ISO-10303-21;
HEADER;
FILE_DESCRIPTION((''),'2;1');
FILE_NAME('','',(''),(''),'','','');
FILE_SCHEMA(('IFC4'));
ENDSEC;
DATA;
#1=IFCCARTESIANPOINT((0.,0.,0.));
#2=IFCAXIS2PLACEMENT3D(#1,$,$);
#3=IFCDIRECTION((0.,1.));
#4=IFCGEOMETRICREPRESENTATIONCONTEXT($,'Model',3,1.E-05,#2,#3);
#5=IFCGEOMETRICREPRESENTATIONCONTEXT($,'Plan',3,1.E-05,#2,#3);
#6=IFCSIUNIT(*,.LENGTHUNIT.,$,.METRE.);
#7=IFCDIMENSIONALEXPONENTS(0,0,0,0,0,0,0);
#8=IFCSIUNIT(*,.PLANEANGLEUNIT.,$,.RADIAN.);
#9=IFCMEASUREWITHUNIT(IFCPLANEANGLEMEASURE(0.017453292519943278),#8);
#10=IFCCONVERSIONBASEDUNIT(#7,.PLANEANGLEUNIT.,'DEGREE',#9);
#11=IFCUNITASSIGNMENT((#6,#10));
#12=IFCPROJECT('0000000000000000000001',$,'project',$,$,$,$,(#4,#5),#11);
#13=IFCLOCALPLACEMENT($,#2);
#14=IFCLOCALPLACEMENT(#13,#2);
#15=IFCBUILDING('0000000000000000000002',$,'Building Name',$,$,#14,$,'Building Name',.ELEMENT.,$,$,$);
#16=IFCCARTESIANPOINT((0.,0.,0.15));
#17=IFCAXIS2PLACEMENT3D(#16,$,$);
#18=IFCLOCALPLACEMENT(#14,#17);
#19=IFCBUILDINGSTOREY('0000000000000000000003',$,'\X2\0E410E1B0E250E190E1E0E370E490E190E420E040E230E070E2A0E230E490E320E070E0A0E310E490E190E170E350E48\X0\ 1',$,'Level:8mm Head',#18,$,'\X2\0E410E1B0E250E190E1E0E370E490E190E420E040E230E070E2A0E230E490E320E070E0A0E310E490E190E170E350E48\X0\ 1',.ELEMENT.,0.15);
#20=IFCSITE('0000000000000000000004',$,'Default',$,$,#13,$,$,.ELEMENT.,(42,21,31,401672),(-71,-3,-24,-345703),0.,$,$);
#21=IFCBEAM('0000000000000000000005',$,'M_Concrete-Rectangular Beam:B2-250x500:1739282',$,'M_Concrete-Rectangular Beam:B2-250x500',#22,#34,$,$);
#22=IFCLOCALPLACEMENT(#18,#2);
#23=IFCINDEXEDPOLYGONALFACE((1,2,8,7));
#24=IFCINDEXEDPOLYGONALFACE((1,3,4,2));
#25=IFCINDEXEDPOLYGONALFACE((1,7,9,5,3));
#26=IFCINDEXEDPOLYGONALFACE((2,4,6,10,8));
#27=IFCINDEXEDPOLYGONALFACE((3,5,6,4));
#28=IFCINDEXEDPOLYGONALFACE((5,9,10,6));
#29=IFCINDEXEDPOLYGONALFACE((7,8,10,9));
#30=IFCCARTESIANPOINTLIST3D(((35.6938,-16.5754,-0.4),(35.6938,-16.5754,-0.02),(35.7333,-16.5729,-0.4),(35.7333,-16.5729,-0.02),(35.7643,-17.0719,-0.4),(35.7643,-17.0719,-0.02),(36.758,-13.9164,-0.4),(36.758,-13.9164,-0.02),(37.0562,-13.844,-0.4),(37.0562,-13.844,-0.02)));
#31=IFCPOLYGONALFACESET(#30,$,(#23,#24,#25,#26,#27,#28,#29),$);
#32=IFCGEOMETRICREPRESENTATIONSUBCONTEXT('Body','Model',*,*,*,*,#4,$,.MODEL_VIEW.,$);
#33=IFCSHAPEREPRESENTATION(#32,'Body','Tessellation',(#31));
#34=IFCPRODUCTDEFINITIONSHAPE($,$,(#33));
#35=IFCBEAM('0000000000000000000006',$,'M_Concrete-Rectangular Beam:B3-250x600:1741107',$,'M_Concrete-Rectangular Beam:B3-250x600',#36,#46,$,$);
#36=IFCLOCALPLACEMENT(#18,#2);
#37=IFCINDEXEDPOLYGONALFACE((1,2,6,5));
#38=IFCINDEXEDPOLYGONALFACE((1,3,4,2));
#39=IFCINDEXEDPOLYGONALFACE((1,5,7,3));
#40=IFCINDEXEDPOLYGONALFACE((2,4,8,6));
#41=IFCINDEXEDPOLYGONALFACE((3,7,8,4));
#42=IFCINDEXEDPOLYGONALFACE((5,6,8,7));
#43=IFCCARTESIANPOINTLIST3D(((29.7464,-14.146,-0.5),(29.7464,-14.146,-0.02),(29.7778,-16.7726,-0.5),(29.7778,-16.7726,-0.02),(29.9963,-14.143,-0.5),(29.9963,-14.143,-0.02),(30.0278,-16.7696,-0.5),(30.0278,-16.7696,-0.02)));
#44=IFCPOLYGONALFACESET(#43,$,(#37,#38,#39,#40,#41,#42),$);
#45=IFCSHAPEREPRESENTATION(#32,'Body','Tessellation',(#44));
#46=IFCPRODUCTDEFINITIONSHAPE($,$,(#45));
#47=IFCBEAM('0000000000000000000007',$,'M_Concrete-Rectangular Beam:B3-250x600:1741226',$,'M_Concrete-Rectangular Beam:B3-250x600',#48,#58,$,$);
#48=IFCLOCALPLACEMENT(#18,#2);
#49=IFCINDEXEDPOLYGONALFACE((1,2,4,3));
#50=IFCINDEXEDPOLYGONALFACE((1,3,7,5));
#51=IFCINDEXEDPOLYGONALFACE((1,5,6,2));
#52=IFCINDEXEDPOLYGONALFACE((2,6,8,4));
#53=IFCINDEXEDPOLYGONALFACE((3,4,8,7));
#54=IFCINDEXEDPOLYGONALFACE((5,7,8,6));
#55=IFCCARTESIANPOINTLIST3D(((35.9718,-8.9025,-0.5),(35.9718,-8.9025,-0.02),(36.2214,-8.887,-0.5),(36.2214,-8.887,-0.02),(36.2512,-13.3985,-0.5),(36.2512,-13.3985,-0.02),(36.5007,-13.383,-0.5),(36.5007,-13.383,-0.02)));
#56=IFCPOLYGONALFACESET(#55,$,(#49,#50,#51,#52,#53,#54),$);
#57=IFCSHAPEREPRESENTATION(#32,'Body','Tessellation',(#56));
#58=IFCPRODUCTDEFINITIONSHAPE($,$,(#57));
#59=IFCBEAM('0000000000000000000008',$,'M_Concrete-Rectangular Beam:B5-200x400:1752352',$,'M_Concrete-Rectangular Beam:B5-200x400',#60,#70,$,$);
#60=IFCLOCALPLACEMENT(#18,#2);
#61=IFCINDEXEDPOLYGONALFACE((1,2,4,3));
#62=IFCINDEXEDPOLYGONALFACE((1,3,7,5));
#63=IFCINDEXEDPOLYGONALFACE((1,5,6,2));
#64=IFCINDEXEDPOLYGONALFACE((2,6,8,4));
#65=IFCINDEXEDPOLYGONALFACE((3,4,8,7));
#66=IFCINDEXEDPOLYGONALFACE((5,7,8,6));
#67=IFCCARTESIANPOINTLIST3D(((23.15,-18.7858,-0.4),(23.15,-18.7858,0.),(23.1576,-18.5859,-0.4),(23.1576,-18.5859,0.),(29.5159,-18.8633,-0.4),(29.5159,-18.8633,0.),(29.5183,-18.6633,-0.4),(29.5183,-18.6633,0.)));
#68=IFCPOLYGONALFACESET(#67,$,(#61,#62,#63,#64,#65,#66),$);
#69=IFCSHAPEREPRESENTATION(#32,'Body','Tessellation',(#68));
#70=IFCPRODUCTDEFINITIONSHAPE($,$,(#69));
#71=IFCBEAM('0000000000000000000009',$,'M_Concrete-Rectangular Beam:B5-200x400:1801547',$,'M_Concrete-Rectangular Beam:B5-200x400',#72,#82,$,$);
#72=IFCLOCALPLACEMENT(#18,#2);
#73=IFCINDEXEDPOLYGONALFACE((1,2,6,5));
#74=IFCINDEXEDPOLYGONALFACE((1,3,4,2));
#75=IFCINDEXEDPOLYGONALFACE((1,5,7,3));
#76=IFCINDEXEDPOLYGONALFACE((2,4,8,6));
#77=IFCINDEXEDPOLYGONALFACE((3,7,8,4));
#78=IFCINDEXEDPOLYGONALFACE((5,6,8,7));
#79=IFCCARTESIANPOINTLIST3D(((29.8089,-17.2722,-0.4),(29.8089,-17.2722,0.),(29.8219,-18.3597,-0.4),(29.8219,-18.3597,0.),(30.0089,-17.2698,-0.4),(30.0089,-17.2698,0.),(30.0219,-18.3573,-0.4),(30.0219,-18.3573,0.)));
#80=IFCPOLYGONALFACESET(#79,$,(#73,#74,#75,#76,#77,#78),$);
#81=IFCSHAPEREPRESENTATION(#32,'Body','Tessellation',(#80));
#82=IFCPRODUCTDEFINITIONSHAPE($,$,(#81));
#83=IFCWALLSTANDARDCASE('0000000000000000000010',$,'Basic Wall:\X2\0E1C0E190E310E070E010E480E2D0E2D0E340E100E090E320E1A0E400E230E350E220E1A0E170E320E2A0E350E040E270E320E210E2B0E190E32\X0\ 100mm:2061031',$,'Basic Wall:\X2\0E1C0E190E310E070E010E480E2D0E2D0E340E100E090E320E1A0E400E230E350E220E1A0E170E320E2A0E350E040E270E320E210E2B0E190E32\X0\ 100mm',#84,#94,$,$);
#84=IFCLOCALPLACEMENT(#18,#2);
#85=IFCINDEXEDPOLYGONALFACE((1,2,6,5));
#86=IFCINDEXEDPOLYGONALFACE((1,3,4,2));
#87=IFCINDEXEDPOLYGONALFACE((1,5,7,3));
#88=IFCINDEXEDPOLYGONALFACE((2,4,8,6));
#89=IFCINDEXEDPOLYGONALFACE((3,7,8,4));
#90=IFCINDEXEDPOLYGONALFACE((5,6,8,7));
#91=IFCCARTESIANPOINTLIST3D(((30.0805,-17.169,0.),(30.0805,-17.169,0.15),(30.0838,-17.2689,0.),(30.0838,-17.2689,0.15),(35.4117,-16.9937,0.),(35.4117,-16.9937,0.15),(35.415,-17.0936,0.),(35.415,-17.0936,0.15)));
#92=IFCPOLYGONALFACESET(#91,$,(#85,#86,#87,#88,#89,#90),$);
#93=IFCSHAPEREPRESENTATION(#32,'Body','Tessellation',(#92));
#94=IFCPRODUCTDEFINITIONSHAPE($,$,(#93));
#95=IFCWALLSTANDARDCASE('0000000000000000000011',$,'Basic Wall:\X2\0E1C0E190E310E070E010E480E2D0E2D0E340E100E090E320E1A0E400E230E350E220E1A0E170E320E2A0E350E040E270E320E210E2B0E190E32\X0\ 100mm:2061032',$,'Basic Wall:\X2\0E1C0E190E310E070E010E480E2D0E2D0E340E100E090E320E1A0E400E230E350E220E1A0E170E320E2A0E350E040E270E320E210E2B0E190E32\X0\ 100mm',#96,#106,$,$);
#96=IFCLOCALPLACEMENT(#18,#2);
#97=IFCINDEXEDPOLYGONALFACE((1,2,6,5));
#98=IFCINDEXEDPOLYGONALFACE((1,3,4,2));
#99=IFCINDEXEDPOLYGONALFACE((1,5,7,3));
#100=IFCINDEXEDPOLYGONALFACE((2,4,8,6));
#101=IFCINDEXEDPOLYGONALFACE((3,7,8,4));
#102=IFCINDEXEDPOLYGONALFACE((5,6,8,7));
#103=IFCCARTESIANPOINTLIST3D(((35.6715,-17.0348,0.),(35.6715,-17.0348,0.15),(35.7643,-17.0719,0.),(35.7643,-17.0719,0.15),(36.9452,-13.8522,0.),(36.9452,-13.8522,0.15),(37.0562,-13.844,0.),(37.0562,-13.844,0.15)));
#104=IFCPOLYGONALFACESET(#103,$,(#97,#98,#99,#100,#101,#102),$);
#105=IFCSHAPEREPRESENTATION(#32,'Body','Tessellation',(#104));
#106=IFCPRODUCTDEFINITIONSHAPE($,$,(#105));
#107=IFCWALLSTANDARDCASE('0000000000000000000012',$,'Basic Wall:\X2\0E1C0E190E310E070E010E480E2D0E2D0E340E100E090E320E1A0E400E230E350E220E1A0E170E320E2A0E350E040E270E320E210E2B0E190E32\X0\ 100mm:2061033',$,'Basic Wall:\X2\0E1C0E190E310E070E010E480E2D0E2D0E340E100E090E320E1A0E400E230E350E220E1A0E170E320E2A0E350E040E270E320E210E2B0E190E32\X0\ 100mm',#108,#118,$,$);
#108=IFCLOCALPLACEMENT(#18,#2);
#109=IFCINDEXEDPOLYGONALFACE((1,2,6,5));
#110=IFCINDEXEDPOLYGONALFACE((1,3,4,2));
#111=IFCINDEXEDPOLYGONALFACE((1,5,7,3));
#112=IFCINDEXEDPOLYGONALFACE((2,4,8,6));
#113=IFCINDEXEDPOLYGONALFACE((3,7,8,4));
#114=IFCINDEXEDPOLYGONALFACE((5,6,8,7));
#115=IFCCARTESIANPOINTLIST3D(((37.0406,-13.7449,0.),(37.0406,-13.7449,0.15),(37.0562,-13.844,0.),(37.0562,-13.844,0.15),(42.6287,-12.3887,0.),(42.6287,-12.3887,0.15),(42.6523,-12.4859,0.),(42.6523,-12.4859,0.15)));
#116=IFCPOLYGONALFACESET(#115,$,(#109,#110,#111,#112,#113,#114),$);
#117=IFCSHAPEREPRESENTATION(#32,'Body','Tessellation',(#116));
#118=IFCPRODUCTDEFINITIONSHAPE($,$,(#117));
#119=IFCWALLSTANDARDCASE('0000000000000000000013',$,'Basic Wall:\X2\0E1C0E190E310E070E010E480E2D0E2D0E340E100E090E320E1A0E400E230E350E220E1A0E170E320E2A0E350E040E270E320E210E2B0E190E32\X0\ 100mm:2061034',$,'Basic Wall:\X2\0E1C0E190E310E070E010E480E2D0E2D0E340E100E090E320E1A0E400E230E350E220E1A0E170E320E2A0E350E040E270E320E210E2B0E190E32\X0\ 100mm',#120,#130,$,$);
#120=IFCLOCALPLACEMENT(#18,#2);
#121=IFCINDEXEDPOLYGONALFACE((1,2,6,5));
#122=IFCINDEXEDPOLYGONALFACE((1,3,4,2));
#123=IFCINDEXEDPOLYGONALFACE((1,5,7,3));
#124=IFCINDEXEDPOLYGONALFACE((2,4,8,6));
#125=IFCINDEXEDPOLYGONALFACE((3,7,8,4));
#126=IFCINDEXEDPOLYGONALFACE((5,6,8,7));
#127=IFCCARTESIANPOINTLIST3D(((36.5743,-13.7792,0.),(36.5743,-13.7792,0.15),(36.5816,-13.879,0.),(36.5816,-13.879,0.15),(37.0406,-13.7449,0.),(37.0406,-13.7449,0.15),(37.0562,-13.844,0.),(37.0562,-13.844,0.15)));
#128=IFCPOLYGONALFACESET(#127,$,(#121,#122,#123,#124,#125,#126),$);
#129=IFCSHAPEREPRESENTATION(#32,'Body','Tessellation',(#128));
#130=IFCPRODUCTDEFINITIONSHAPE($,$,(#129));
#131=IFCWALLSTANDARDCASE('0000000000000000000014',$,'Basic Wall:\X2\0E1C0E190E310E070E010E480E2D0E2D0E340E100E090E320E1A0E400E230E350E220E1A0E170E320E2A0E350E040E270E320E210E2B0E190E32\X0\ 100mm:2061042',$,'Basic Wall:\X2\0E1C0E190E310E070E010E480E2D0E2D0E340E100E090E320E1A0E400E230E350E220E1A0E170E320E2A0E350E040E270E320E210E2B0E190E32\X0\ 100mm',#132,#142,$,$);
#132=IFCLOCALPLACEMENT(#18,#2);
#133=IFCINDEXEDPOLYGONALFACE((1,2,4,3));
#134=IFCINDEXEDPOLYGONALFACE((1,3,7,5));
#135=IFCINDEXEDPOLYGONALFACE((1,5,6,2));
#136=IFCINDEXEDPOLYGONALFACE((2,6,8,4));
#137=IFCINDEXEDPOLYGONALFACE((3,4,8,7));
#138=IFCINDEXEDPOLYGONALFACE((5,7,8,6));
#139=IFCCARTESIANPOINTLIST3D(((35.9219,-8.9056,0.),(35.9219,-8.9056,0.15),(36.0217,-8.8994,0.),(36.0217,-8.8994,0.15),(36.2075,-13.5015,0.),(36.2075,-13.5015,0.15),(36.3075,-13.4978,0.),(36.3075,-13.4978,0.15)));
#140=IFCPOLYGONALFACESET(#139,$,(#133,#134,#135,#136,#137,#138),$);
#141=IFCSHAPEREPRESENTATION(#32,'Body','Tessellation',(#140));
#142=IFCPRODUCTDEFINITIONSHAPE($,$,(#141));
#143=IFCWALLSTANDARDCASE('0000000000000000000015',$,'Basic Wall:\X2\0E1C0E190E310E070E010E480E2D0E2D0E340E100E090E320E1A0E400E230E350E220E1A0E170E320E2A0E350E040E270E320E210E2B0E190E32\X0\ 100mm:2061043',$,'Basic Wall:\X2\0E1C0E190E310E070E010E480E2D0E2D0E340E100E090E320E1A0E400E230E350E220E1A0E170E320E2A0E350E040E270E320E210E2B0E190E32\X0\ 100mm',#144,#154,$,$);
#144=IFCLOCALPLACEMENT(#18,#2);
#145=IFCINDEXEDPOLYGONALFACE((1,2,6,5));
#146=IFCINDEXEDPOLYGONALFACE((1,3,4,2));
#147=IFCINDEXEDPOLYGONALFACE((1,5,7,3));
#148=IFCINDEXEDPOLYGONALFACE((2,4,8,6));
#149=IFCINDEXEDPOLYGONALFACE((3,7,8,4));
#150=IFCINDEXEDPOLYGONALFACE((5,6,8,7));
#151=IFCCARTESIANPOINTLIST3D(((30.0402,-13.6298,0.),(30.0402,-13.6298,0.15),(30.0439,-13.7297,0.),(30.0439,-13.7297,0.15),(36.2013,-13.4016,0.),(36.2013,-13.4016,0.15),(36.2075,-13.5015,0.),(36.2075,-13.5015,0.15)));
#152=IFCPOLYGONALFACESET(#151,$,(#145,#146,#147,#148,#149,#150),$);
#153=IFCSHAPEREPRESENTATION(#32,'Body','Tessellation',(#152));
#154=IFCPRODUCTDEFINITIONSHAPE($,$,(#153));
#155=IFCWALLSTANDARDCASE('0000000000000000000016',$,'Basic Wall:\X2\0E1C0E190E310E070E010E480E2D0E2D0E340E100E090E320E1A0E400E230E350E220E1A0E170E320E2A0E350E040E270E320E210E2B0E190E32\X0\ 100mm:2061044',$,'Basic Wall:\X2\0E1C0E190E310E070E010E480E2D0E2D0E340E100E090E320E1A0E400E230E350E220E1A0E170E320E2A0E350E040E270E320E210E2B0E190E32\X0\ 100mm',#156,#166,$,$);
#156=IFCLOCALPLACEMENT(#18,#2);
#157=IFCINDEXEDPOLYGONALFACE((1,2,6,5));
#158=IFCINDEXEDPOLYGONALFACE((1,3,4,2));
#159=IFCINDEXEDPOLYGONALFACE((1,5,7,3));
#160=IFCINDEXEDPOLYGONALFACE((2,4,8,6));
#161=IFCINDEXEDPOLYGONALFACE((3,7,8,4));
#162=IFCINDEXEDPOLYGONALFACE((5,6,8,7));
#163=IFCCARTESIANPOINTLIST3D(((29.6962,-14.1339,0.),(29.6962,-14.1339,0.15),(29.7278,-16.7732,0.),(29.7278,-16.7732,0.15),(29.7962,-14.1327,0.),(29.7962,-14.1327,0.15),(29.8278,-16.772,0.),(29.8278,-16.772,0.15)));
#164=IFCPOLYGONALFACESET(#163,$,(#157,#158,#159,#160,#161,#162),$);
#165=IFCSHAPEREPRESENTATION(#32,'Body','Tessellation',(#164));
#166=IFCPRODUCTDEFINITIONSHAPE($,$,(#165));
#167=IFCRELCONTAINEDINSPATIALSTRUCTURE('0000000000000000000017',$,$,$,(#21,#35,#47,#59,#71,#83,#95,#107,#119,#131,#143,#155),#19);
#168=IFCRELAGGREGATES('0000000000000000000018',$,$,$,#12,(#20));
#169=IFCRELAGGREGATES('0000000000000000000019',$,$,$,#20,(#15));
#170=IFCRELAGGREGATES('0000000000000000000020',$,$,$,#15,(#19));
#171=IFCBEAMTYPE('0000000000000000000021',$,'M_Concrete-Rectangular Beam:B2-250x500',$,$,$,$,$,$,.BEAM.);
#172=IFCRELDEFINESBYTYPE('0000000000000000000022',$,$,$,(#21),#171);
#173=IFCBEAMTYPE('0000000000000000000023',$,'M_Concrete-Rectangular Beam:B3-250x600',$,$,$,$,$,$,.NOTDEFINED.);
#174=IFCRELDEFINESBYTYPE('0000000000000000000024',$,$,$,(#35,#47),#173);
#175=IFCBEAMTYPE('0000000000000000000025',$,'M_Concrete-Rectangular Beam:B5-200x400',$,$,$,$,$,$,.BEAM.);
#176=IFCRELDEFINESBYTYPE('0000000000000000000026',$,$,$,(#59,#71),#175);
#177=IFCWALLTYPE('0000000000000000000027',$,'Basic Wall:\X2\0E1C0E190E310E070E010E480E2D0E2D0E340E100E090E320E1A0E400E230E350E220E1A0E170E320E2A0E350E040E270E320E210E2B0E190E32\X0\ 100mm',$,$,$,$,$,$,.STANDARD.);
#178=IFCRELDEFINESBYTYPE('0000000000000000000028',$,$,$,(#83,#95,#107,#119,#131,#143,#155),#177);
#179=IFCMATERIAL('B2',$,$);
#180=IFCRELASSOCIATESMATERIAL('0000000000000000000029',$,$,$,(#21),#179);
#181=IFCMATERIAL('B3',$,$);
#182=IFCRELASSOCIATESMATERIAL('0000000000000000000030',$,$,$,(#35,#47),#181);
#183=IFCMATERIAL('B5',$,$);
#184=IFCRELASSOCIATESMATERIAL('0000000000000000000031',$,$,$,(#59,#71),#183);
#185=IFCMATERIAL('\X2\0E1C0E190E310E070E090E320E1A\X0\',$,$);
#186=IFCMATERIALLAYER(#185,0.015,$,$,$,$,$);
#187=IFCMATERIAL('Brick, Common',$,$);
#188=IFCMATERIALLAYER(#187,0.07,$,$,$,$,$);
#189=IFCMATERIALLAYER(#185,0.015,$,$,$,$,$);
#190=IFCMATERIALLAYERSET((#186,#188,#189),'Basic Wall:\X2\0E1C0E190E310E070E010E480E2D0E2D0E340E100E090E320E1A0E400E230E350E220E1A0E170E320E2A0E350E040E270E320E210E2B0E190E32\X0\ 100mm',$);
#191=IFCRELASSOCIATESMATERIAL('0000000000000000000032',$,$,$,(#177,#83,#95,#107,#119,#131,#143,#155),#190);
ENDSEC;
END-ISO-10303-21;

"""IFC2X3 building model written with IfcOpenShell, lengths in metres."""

from ifc_helpers import new_model, entity, si_unit, converted_unit, direction, frame, frame_2d, origin, origin_2d_with_axis, place, context, subcontext, project, spatial, polyline, rectangle, outline, extrude, clip, halfspace, bounded_halfspace, material, layer, layer_set, layer_usage, type_object, element, save


model = new_model("IFC2X3")

# Units and contexts
model_context = context("Model", 3, precision=1e-05, world=origin(), true_north=direction((0.0, 1.0)))
plan_context = context("Plan", 3, precision=1e-05, world=origin(), true_north=direction((0.0, 1.0)))
body_context = subcontext(model_context, "Body", "Model", "MODEL_VIEW")
ifc_project = project(units=[si_unit("LENGTHUNIT", "METRE"), converted_unit("PLANEANGLEUNIT", "DEGREE", entity("IfcPlaneAngleMeasure", 0.017453292519943278), si_unit("PLANEANGLEUNIT", "RADIAN"), dimensions=[0, 0, 0, 0, 0, 0, 0])], contexts=[model_context, plan_context])

# Site, building, storey
site_placement = place(None, origin())
site = spatial("IfcSite", under=ifc_project, at=site_placement, Name="Default", CompositionType="ELEMENT", RefLatitude=(42, 21, 31, 401672), RefLongitude=(-71, -3, -24, -345703), RefElevation=0.0)
building_placement = place(site_placement, origin())
building = spatial("IfcBuilding", under=site, at=building_placement, Name="Building Name", LongName="Building Name", CompositionType="ELEMENT")
storey_placement = place(building_placement, frame((0.0, 0.0, 0.15)))
storey = spatial("IfcBuildingStorey", under=building, at=storey_placement, Name="แปลนพื้นโครงสร้างชั้นที่ 1", ObjectType="Level:8mm Head", LongName="แปลนพื้นโครงสร้างชั้นที่ 1", CompositionType="ELEMENT", Elevation=0.15)

# Beams
ifc_material_1 = material(Name="B2")
beam_type_1 = type_object("IfcBeamType", Name="M_Concrete-Rectangular Beam:B2-250x500", PredefinedType="BEAM")
beam_1_placement = place(storey_placement, frame((37.0562, -13.844, 0.0), z_axis=(0.0, 0.0, 1.0), x_axis=(-0.371573, -0.928404, 0.0)))
element("IfcBeam", 1, at=beam_1_placement, inside=storey, type_object=beam_type_1, material=ifc_material_1, Name="M_Concrete-Rectangular Beam:B2-250x500:1739282", ObjectType="M_Concrete-Rectangular Beam:B2-250x500", context=body_context, shape_type="Clipping", body=[
    clip(clip(clip(extrude(rectangle(XDim=0.38, YDim=0.25, at=frame_2d((0.0, 0.0), x_axis=(1.0, 0.0))), frame((0.0, -0.125, -0.21), z_axis=(1.0, 0.0, 0.0), x_axis=(0.0, 0.0, -1.0)), (0.0, 0.0, 1.0), 3.4768), halfspace(frame((0.2918, -0.4098, -0.4), z_axis=(-0.814578, -0.580053, 0.0), x_axis=(-0.580053, 0.814578, 0.0)), False)), bounded_halfspace(frame((3.4768, 0.0, 5.1), z_axis=(0.428432, -0.903574, 0.0), x_axis=(0.0, 0.0, -1.0)), False, frame((0.0, -0.125, -0.21), z_axis=(1.0, 0.0, 0.0), x_axis=(0.0, 0.0, -1.0)), polyline([(0.19, -0.0892), (0.19, 0.125), (-0.19, 0.125), (-0.19, -0.0892), (0.19, -0.0892)]))), bounded_halfspace(frame((3.0251, -0.2142, 5.1), z_axis=(0.903574, 0.428432, 0.0), x_axis=(0.0, 0.0, -1.0)), False, frame((0.0, -0.125, -0.21), z_axis=(1.0, 0.0, 0.0), x_axis=(0.0, 0.0, -1.0)), polyline([(0.19, -0.125), (0.19, -0.0892), (-0.19, -0.0892), (-0.19, -0.125), (0.19, -0.125)]))),
])
ifc_material_2 = material(Name="B3")
beam_type_2 = type_object("IfcBeamType", Name="M_Concrete-Rectangular Beam:B3-250x600", PredefinedType="NOTDEFINED")
beam_2_placement = place(storey_placement, frame((29.9028, -16.7711, 0.0), z_axis=(0.0, 0.0, 1.0), x_axis=(-0.011969, 0.999928, 0.0)))
element("IfcBeam", 2, at=beam_2_placement, inside=storey, type_object=beam_type_2, material=ifc_material_2, Name="M_Concrete-Rectangular Beam:B3-250x600:1741107", ObjectType="M_Concrete-Rectangular Beam:B3-250x600", context=body_context, shape_type="SweptSolid", body=[
    extrude(rectangle(XDim=0.48, YDim=0.25, at=frame_2d((0.0, 0.0), x_axis=(1.0, 0.0))), frame((0.0, 0.0, -0.26), z_axis=(1.0, 0.0, 0.0), x_axis=(0.0, 0.0, -1.0)), (0.0, 0.0, 1.0), 2.6267),
])
beam_3_placement = place(storey_placement, frame((36.3915, -13.6403, 0.0), z_axis=(0.0, 0.0, 1.0), x_axis=(-0.062014, 0.998075, 0.0)))
element("IfcBeam", 3, at=beam_3_placement, inside=storey, type_object=beam_type_2, material=ifc_material_2, Name="M_Concrete-Rectangular Beam:B3-250x600:1741226", ObjectType="M_Concrete-Rectangular Beam:B3-250x600", context=body_context, shape_type="SweptSolid", body=[
    extrude(rectangle(XDim=0.48, YDim=0.25, at=frame_2d((0.0, 0.0), x_axis=(1.0, 0.0))), frame((0.25, 0.0, -0.26), z_axis=(1.0, 0.0, 0.0), x_axis=(0.0, 0.0, -1.0)), (0.0, 0.0, 1.0), 4.5047),
])
ifc_material_3 = material(Name="B5")
beam_type_3 = type_object("IfcBeamType", Name="M_Concrete-Rectangular Beam:B5-200x400", PredefinedType="BEAM")
beam_4_placement = place(storey_placement, frame((29.5159, -18.8633, 0.0), z_axis=(0.0, 0.0, 1.0), x_axis=(-0.999926, 0.01216, 0.0)))
element("IfcBeam", 4, at=beam_4_placement, inside=storey, type_object=beam_type_3, material=ifc_material_3, Name="M_Concrete-Rectangular Beam:B5-200x400:1752352", ObjectType="M_Concrete-Rectangular Beam:B5-200x400", context=body_context, shape_type="Clipping", body=[
    clip(extrude(rectangle(XDim=0.4, YDim=0.2, at=origin_2d_with_axis()), frame((0.0, -0.1, -0.2), z_axis=(1.0, 0.0, 0.0), x_axis=(0.0, 0.0, -1.0)), (0.0, 0.0, 1.0), 6.3664), halfspace(frame((6.3612, -0.2, 0.0), z_axis=(0.999667, -0.025823, 0.0), x_axis=(-0.025823, -0.999667, 0.0)), False)),
])
beam_5_placement = place(storey_placement, frame((30.0089, -17.2698, 0.0), z_axis=(0.0, 0.0, 1.0), x_axis=(0.011969, -0.999928, 0.0)))
element("IfcBeam", 5, at=beam_5_placement, inside=storey, type_object=beam_type_3, material=ifc_material_3, Name="M_Concrete-Rectangular Beam:B5-200x400:1801547", ObjectType="M_Concrete-Rectangular Beam:B5-200x400", context=body_context, shape_type="SweptSolid", body=[
    extrude(rectangle(XDim=0.4, YDim=0.2, at=frame_2d((0.0, 0.0), x_axis=(1.0, 0.0))), frame((0.0, -0.1, -0.2), z_axis=(1.0, 0.0, 0.0), x_axis=(0.0, 0.0, -1.0)), (0.0, 0.0, 1.0), 1.0876),
])

# Walls
ifc_material_4 = material(Name="ผนังฉาบ")
ifc_layer_1 = layer(ifc_material_4, 0.015)
ifc_material_5 = material(Name="Brick, Common")
ifc_layer_2 = layer(ifc_material_5, 0.07)
ifc_layer_3 = layer(ifc_material_4, 0.015)
ifc_layer_set_1 = layer_set([ifc_layer_1, ifc_layer_2, ifc_layer_3], Name="Basic Wall:ผนังก่ออิฐฉาบเรียบทาสีความหนา 100mm")
ifc_layer_usage_1 = layer_usage(ifc_layer_set_1, "AXIS2", "POSITIVE", -0.05)
wall_type_1 = type_object("IfcWallType", Name="Basic Wall:ผนังก่ออิฐฉาบเรียบทาสีความหนา 100mm", PredefinedType="STANDARD", material=ifc_layer_set_1)
wall_1_placement = place(storey_placement, frame((30.0821, -17.219, 0.0), z_axis=(0.0, 0.0, 1.0), x_axis=(0.99946, 0.032862, 0.0)))
element("IfcWallStandardCase", 6, at=wall_1_placement, inside=storey, type_object=wall_type_1, material=ifc_layer_usage_1, Name="Basic Wall:ผนังก่ออิฐฉาบเรียบทาสีความหนา 100mm:2061031", ObjectType="Basic Wall:ผนังก่ออิฐฉาบเรียบทาสีความหนา 100mm", context=body_context, shape_type="Clipping", body=[
    clip(extrude(rectangle(XDim=5.3341, YDim=0.1, at=frame_2d((2.6671, 0.0), x_axis=(-1.0, 0.0))), origin(), (0.0, 0.0, 1.0), 0.15), halfspace(origin(), True)),
])
ifc_layer_usage_2 = layer_usage(ifc_layer_set_1, "AXIS2", "POSITIVE", -0.05)
wall_2_placement = place(storey_placement, frame((35.7179, -17.0534, 0.0), z_axis=(0.0, 0.0, 1.0), x_axis=(0.371573, 0.928404, 0.0)))
element("IfcWallStandardCase", 7, at=wall_2_placement, inside=storey, type_object=wall_type_1, material=ifc_layer_usage_2, Name="Basic Wall:ผนังก่ออิฐฉาบเรียบทาสีความหนา 100mm:2061032", ObjectType="Basic Wall:ผนังก่ออิฐฉาบเรียบทาสีความหนา 100mm", context=body_context, shape_type="Clipping", body=[
    clip(extrude(outline(polyline([(3.4768, -0.05), (3.428, 0.05), (0.0, 0.05), (0.0, -0.05), (3.4768, -0.05)])), origin(), (0.0, 0.0, 1.0), 0.15), halfspace(origin(), True)),
])
ifc_layer_usage_3 = layer_usage(ifc_layer_set_1, "AXIS2", "POSITIVE", -0.05)
wall_3_placement = place(storey_placement, frame((37.0444, -13.7954, 0.0), z_axis=(0.0, 0.0, 1.0), x_axis=(0.97179, 0.235849, 0.0)))
element("IfcWallStandardCase", 8, at=wall_3_placement, inside=storey, type_object=wall_type_1, material=ifc_layer_usage_3, Name="Basic Wall:ผนังก่ออิฐฉาบเรียบทาสีความหนา 100mm:2061033", ObjectType="Basic Wall:ผนังก่ออิฐฉาบเรียบทาสีความหนา 100mm", context=body_context, shape_type="Clipping", body=[
    clip(extrude(outline(polyline([(5.7585, -0.05), (5.7585, 0.05), (4.3098, 0.05), (4.209, 0.05), (0.0082, 0.05), (0.0, -0.05), (5.7585, -0.05)])), origin(), (0.0, 0.0, 1.0), 0.15), halfspace(origin(), True)),
])
ifc_layer_usage_4 = layer_usage(ifc_layer_set_1, "AXIS2", "POSITIVE", -0.05)
wall_4_placement = place(storey_placement, frame((36.578, -13.8291, 0.0), z_axis=(0.0, 0.0, 1.0), x_axis=(0.997301, 0.073417, 0.0)))
element("IfcWallStandardCase", 9, at=wall_4_placement, inside=storey, type_object=wall_type_1, material=ifc_layer_usage_4, Name="Basic Wall:ผนังก่ออิฐฉาบเรียบทาสีความหนา 100mm:2061034", ObjectType="Basic Wall:ผนังก่ออิฐฉาบเรียบทาสีความหนา 100mm", context=body_context, shape_type="Clipping", body=[
    clip(extrude(outline(polyline([(0.4759, -0.05), (0.4676, 0.05), (0.0, 0.05), (0.0, -0.05), (0.3646, -0.05), (0.4759, -0.05)])), origin(), (0.0, 0.0, 1.0), 0.15), halfspace(origin(), True)),
])
ifc_layer_usage_5 = layer_usage(ifc_layer_set_1, "AXIS2", "POSITIVE", -0.05)
wall_5_placement = place(storey_placement, frame((35.9718, -8.9025, 0.0), z_axis=(0.0, 0.0, 1.0), x_axis=(0.062014, -0.998075, 0.0)))
element("IfcWallStandardCase", 10, at=wall_5_placement, inside=storey, type_object=wall_type_1, material=ifc_layer_usage_5, Name="Basic Wall:ผนังก่ออิฐฉาบเรียบทาสีความหนา 100mm:2061042", ObjectType="Basic Wall:ผนังก่ออิฐฉาบเรียบทาสีความหนา 100mm", context=body_context, shape_type="Clipping", body=[
    clip(extrude(outline(polyline([(4.6047, -0.05), (4.6072, 0.05), (0.0, 0.05), (0.0, -0.05), (4.5047, -0.05), (4.6047, -0.05)])), origin(), (0.0, 0.0, 1.0), 0.15), halfspace(origin(), True)),
])
ifc_layer_usage_6 = layer_usage(ifc_layer_set_1, "AXIS2", "POSITIVE", -0.05)
wall_6_placement = place(storey_placement, frame((36.2056, -13.4515, 0.0), z_axis=(0.0, 0.0, 1.0), x_axis=(-0.999315, -0.037003, 0.0)))
element("IfcWallStandardCase", 11, at=wall_6_placement, inside=storey, type_object=wall_type_1, material=ifc_layer_usage_6, Name="Basic Wall:ผนังก่ออิฐฉาบเรียบทาสีความหนา 100mm:2061043", ObjectType="Basic Wall:ผนังก่ออิฐฉาบเรียบทาสีความหนา 100mm", context=body_context, shape_type="Clipping", body=[
    clip(extrude(outline(polyline([(6.1678, -0.05), (6.1678, 0.05), (0.0, 0.05), (0.0025, -0.05), (6.1678, -0.05)])), origin(), (0.0, 0.0, 1.0), 0.15), halfspace(origin(), True)),
])
ifc_layer_usage_7 = layer_usage(ifc_layer_set_1, "AXIS2", "POSITIVE", -0.05)
wall_7_placement = place(storey_placement, frame((29.7462, -14.1333, 0.0), z_axis=(0.0, 0.0, 1.0), x_axis=(0.011969, -0.999928, 0.0)))
element("IfcWallStandardCase", 12, at=wall_7_placement, inside=storey, type_object=wall_type_1, material=ifc_layer_usage_7, Name="Basic Wall:ผนังก่ออิฐฉาบเรียบทาสีความหนา 100mm:2061044", ObjectType="Basic Wall:ผนังก่ออิฐฉาบเรียบทาสีความหนา 100mm", context=body_context, shape_type="Clipping", body=[
    clip(extrude(rectangle(XDim=2.6394, YDim=0.1, at=frame_2d((1.3197, 0.0), x_axis=(-1.0, 0.0))), origin(), (0.0, 0.0, 1.0), 0.15), halfspace(origin(), True)),
])

save(model, "model.ifc")
